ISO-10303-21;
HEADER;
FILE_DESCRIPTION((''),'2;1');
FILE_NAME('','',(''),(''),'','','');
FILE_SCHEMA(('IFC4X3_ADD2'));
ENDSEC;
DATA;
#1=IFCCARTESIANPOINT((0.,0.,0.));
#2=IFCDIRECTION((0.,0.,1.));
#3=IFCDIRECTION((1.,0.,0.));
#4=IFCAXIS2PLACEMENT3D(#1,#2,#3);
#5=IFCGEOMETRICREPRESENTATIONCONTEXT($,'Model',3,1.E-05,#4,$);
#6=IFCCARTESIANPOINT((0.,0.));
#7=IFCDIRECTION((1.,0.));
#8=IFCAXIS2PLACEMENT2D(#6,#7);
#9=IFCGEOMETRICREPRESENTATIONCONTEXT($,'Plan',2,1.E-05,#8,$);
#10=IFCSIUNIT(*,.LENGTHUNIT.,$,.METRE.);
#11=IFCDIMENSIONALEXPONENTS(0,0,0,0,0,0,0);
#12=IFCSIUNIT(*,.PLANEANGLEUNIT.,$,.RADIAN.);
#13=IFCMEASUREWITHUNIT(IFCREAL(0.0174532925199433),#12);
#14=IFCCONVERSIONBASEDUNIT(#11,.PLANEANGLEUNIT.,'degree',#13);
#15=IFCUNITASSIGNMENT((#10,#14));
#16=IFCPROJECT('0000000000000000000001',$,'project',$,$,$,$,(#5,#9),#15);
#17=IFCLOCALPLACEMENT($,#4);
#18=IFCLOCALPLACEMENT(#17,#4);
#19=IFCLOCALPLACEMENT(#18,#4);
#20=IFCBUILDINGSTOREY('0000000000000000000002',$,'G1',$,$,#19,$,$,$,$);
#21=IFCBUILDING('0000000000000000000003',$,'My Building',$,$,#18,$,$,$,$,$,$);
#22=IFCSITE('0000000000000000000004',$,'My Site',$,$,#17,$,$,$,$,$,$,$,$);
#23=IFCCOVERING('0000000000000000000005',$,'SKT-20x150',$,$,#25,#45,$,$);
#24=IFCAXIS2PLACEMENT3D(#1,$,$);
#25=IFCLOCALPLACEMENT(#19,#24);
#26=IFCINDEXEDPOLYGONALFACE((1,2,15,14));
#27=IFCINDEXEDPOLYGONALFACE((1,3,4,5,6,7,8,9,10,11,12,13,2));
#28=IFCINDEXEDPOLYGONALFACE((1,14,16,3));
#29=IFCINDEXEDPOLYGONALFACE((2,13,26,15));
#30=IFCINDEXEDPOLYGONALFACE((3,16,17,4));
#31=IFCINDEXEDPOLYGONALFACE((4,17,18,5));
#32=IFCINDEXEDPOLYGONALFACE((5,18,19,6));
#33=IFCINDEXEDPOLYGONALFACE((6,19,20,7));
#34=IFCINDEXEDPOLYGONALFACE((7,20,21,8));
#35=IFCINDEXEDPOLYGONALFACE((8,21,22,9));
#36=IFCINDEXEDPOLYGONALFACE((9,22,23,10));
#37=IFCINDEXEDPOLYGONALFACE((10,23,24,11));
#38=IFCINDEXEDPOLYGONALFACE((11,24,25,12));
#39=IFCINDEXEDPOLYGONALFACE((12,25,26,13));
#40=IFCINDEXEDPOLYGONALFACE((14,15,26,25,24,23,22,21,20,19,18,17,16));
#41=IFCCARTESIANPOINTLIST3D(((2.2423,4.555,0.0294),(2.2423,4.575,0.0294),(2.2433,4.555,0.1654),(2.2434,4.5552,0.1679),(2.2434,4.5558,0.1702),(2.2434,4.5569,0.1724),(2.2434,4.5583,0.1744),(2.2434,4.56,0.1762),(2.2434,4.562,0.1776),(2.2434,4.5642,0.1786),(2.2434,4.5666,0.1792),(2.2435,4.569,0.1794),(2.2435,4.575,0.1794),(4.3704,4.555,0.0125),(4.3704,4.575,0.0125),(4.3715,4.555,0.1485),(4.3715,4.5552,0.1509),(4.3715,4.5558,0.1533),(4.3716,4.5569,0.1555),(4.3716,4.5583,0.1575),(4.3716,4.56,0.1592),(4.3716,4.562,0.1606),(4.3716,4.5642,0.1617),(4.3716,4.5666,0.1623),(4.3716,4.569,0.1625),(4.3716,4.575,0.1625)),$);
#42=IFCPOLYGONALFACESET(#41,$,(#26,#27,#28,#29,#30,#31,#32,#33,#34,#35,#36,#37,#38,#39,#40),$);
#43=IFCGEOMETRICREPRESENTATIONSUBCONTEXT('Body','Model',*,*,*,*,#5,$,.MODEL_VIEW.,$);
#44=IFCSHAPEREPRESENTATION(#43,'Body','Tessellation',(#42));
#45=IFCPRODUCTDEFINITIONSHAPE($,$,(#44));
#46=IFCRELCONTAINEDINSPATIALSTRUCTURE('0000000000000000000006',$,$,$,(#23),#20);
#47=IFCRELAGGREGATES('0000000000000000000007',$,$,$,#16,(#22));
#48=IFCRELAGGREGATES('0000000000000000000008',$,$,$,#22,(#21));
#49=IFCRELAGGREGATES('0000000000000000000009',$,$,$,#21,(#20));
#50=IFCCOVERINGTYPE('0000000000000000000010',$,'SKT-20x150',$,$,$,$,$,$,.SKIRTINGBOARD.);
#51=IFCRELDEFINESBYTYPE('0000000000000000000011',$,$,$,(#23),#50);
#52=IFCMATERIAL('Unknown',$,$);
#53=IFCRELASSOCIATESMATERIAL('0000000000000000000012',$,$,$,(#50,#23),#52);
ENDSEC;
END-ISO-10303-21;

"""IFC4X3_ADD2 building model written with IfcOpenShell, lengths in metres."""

from ifc_helpers import new_model, entity, si_unit, converted_unit, frame, origin_with_axes, origin_2d_with_axis, place, context, subcontext, project, spatial, indexed_curve, outline, extrude, material, material_profile, profile_set, profile_usage, type_object, element, save


model = new_model("IFC4X3_ADD2")

# Units and contexts
model_context = context("Model", 3, precision=1e-05, world=origin_with_axes())
plan_context = context("Plan", 2, precision=1e-05, world=origin_2d_with_axis())
body_context = subcontext(model_context, "Body", "Model", "MODEL_VIEW")
ifc_project = project(units=[si_unit("LENGTHUNIT", "METRE"), converted_unit("PLANEANGLEUNIT", "degree", entity("IfcReal", 0.0174532925199433), si_unit("PLANEANGLEUNIT", "RADIAN"), dimensions=[0, 0, 0, 0, 0, 0, 0])], contexts=[model_context, plan_context])

# Site, building, storey
site_placement = place(None, origin_with_axes())
site = spatial("IfcSite", under=ifc_project, at=site_placement, Name="My Site")
building_placement = place(site_placement, origin_with_axes())
building = spatial("IfcBuilding", under=site, at=building_placement, Name="My Building")
storey_placement = place(building_placement, origin_with_axes())
storey = spatial("IfcBuildingStorey", under=building, at=storey_placement, Name="G1")

# Covering
ifc_material_1 = material(Name="Unknown")
ifc_material_profile_1 = material_profile(ifc_material_1, outline(indexed_curve([(0.0, 0.0), (0.02, 0.0), (0.02, 0.136), (0.0198, 0.1384), (0.0192, 0.1408), (0.0181, 0.143), (0.0167, 0.145), (0.015, 0.1467), (0.013, 0.1481), (0.0108, 0.1492), (0.0084, 0.1498), (0.006, 0.15), (0.0, 0.15), (0.0, 0.0)])))
ifc_profile_set_1 = profile_set([ifc_material_profile_1])
covering_type_1 = type_object("IfcCoveringType", Name="SKT-20x150", PredefinedType="SKIRTINGBOARD", material=ifc_profile_set_1)
ifc_profile_usage_1 = profile_usage(ifc_profile_set_1, cardinal=1)
covering_1_placement = place(storey_placement, frame((4.3698, 4.565, -0.0625), z_axis=(-0.999968, 0.0, 0.007961), x_axis=(0.0, -1.0, 0.0)))
element("IfcCovering", 1, at=covering_1_placement, inside=storey, type_object=covering_type_1, material=ifc_profile_usage_1, Name="SKT-20x150", context=body_context, shape_type="SweptSolid", body=[
    extrude(outline(indexed_curve([(0.0, 0.0), (0.02, 0.0), (0.02, 0.136), (0.0198, 0.1384), (0.0192, 0.1408), (0.0181, 0.143), (0.0167, 0.145), (0.015, 0.1467), (0.013, 0.1481), (0.0108, 0.1492), (0.0084, 0.1498), (0.006, 0.15), (0.0, 0.15), (0.0, 0.0)])), frame((-0.01, 0.075, 0.0), z_axis=(0.0, 0.0, 1.0), x_axis=(1.0, 0.0, 0.0)), (0.0, 0.0, 1.0), 2.1282),
])

save(model, "model.ifc")
